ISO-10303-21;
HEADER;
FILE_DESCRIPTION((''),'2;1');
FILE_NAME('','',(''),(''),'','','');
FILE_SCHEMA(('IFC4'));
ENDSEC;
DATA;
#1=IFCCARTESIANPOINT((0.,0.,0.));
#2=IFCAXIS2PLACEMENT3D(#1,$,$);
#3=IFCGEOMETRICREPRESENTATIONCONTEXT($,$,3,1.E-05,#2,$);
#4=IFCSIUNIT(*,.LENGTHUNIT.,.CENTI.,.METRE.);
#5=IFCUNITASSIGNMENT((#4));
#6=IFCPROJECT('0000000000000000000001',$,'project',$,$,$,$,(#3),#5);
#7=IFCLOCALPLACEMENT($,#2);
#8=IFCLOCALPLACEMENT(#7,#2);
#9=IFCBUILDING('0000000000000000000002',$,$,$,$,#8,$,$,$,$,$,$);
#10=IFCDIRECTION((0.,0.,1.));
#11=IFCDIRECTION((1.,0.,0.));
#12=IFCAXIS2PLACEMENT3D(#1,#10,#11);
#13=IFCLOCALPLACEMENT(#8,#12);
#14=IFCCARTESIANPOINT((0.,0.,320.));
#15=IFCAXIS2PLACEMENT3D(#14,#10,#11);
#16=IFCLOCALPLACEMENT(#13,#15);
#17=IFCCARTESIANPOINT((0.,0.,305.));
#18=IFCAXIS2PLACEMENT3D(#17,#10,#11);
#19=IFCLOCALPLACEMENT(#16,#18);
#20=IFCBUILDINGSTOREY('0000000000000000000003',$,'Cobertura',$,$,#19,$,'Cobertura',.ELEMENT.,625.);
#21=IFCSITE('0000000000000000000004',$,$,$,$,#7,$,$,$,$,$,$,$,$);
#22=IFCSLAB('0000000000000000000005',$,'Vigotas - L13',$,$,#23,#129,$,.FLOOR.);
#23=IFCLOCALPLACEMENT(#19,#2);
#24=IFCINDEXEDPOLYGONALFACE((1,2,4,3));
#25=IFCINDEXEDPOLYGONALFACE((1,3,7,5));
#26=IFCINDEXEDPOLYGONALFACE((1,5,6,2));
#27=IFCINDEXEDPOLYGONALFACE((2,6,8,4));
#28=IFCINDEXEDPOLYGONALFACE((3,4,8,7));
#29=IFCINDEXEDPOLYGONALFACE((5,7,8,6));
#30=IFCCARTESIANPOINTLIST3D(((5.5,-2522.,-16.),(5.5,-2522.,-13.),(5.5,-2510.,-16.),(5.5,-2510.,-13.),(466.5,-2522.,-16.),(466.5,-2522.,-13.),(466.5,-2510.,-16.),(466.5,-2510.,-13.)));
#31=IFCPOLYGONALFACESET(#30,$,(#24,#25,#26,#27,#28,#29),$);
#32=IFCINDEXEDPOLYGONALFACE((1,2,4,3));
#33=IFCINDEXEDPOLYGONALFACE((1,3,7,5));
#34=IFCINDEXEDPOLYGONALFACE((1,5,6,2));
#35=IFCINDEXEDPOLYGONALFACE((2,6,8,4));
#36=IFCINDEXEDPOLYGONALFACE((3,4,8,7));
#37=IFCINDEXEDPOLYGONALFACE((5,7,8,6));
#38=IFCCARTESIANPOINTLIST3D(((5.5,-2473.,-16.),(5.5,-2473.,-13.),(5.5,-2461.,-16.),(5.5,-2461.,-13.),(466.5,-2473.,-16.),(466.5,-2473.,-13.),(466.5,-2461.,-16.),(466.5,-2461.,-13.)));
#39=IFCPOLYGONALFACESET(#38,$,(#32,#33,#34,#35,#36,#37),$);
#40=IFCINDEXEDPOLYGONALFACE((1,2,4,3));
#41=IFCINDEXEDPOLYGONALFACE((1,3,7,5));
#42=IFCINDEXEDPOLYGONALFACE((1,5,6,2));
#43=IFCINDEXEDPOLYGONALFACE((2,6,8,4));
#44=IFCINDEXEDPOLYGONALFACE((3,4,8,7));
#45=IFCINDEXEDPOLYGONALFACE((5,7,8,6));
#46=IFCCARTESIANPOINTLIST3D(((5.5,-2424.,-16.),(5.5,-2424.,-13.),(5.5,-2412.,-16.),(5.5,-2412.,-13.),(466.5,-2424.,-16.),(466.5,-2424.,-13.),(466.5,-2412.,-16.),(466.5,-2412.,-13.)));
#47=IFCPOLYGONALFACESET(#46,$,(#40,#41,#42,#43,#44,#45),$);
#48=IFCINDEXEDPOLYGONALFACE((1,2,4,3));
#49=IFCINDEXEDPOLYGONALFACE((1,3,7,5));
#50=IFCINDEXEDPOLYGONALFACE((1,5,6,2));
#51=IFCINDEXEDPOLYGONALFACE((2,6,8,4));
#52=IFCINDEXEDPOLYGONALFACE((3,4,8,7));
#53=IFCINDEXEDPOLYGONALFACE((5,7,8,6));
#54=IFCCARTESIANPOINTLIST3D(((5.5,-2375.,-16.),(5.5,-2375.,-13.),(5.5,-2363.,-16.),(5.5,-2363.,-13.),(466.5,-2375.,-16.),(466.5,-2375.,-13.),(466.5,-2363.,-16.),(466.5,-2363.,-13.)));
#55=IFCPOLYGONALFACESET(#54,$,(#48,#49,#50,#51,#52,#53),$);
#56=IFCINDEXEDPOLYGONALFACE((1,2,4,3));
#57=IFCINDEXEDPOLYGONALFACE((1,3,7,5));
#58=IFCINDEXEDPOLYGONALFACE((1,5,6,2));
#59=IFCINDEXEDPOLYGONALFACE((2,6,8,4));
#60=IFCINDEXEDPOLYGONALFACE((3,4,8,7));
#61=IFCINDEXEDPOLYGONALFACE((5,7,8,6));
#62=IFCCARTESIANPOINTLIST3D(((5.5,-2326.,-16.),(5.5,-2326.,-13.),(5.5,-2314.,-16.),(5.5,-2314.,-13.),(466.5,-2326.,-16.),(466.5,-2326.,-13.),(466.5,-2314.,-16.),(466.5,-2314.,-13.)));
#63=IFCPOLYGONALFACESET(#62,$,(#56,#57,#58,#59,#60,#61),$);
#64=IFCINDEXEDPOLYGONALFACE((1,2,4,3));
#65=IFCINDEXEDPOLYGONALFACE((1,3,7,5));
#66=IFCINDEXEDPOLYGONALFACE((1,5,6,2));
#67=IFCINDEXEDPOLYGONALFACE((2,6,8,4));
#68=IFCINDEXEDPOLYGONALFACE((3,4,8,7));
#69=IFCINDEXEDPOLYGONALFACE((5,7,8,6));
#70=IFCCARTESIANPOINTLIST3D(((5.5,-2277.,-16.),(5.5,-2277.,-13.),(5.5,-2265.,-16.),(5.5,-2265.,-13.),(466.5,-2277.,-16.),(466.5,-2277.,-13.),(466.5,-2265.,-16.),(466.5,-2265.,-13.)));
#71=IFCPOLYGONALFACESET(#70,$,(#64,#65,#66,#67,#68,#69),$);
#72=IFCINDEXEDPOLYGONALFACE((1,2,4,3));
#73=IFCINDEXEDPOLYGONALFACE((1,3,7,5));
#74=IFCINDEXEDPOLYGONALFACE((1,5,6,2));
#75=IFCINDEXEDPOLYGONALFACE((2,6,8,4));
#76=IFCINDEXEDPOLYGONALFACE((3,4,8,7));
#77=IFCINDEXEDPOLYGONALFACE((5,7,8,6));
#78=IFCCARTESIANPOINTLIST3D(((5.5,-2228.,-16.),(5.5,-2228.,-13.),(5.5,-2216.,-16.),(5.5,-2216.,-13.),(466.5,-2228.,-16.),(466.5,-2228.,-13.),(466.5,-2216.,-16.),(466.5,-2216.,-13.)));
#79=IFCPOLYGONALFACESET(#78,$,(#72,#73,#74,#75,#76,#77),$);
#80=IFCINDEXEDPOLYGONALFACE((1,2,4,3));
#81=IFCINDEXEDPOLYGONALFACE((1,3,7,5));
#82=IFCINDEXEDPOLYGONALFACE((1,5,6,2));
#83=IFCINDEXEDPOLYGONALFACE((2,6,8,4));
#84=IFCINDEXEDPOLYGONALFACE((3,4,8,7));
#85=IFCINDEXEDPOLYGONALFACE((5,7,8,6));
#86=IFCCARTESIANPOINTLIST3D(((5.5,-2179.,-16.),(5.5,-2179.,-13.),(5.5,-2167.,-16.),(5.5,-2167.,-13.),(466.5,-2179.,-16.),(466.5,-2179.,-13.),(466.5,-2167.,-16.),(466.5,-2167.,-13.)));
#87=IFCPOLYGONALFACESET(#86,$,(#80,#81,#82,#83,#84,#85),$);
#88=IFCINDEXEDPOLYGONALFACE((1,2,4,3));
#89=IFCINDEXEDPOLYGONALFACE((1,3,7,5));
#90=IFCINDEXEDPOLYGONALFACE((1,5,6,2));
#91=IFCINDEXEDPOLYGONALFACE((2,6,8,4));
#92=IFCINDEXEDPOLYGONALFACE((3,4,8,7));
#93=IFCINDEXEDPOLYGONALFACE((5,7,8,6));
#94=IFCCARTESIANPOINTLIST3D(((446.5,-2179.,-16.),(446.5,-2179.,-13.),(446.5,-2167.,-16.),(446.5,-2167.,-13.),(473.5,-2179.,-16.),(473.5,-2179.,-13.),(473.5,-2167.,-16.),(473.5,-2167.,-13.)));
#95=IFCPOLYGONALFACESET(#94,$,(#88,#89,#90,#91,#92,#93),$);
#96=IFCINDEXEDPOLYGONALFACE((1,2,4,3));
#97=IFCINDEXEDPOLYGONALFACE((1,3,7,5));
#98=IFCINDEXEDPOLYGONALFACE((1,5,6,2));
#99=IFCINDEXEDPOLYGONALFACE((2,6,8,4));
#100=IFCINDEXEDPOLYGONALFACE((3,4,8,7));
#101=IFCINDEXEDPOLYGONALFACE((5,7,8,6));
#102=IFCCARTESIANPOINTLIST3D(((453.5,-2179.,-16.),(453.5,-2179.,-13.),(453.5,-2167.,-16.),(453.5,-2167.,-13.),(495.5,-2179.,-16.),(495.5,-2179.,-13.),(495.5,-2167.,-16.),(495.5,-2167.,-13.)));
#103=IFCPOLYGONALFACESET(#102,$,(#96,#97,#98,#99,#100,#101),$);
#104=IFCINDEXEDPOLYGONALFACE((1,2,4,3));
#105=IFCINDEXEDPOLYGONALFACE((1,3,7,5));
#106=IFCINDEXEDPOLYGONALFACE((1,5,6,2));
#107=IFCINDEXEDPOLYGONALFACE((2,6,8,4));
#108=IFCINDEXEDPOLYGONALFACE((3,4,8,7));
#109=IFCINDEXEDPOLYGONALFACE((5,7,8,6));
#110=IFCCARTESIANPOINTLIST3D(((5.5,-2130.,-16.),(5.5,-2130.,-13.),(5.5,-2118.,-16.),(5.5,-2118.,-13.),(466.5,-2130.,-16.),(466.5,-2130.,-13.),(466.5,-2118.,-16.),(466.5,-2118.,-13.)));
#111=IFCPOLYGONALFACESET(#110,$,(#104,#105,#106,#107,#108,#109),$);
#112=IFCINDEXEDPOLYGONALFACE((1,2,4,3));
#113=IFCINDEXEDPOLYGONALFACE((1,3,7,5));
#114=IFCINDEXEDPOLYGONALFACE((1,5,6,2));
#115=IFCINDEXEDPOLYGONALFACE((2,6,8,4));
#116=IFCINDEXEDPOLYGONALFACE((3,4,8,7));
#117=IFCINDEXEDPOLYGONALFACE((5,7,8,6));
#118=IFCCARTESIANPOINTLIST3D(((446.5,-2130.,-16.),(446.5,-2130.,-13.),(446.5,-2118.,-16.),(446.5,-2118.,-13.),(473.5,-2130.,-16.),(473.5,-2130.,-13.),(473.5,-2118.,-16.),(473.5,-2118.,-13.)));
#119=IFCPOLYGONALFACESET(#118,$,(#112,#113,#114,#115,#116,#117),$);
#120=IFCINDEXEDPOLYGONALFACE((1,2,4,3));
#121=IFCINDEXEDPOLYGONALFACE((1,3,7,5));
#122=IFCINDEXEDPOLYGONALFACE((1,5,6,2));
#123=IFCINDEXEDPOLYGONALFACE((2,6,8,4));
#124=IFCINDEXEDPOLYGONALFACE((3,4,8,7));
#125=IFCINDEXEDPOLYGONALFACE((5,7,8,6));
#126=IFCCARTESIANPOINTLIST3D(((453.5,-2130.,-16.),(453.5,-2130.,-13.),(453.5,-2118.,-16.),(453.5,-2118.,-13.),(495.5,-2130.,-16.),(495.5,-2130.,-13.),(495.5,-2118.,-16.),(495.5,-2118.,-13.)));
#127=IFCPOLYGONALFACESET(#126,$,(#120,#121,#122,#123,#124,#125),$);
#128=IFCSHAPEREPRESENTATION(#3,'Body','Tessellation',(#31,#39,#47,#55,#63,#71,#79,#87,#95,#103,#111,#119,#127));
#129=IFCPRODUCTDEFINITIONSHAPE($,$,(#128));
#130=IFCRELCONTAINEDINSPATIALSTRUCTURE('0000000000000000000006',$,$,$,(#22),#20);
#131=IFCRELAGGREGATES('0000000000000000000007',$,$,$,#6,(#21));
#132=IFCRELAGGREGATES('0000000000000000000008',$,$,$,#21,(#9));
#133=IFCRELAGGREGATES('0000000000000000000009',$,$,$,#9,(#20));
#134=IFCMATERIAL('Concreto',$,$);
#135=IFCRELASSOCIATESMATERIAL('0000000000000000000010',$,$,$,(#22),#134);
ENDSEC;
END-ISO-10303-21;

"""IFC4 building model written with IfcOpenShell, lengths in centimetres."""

from ifc_helpers import new_model, si_unit, frame, origin, origin_with_axes, place, context, project, spatial, polyline, outline, extrude, material, element, save


model = new_model("IFC4")

# Units and contexts
context_of_model = context(None, 3, precision=1e-05, world=origin())
ifc_project = project(units=[si_unit("LENGTHUNIT", "METRE", prefix="CENTI")], contexts=[context_of_model])

# Site, building, storey
site_placement = place(None, origin())
site = spatial("IfcSite", under=ifc_project, at=site_placement)
building_placement = place(site_placement, origin())
building = spatial("IfcBuilding", under=site, at=building_placement)
placement_1 = place(building_placement, origin_with_axes())
placement_2 = place(placement_1, frame((0.0, 0.0, 320.0), z_axis=(0.0, 0.0, 1.0), x_axis=(1.0, 0.0, 0.0)))
storey_placement = place(placement_2, frame((0.0, 0.0, 305.0), z_axis=(0.0, 0.0, 1.0), x_axis=(1.0, 0.0, 0.0)))
storey = spatial("IfcBuildingStorey", under=building, at=storey_placement, Name="Cobertura", LongName="Cobertura", CompositionType="ELEMENT", Elevation=625.0)

# Shared definitions
ifc_material = material(Name="Concreto")

# Slab
slab_1_placement = place(storey_placement, frame((250.5, -2320.0, -13.0), z_axis=(0.0, 0.0, 1.0), x_axis=(1.0, 0.0, 0.0)))
element("IfcSlab", 1, at=slab_1_placement, inside=storey, material=ifc_material, Name="Vigotas - L13", PredefinedType="FLOOR", context=context_of_model, shape_type="SolidModel", body=[
    extrude(outline(polyline([(6.0, 1.5), (-6.0, 1.5), (-6.0, -1.5), (6.0, -1.5), (6.0, 1.5), (6.0, 1.5)])), frame((-245.0, -196.0, -1.5), z_axis=(1.0, 0.0, 0.0), x_axis=(0.0, -1.0, 0.0)), (0.0, 0.0, 1.0), 461.0),
    extrude(outline(polyline([(6.0, 1.5), (-6.0, 1.5), (-6.0, -1.5), (6.0, -1.5), (6.0, 1.5), (6.0, 1.5)])), frame((-245.0, -147.0, -1.5), z_axis=(1.0, 0.0, 0.0), x_axis=(0.0, -1.0, 0.0)), (0.0, 0.0, 1.0), 461.0),
    extrude(outline(polyline([(6.0, 1.5), (-6.0, 1.5), (-6.0, -1.5), (6.0, -1.5), (6.0, 1.5), (6.0, 1.5)])), frame((-245.0, -98.0, -1.5), z_axis=(1.0, 0.0, 0.0), x_axis=(0.0, -1.0, 0.0)), (0.0, 0.0, 1.0), 461.0),
    extrude(outline(polyline([(6.0, 1.5), (-6.0, 1.5), (-6.0, -1.5), (6.0, -1.5), (6.0, 1.5), (6.0, 1.5)])), frame((-245.0, -49.0, -1.5), z_axis=(1.0, 0.0, 0.0), x_axis=(0.0, -1.0, 0.0)), (0.0, 0.0, 1.0), 461.0),
    extrude(outline(polyline([(6.0, 1.5), (-6.0, 1.5), (-6.0, -1.5), (6.0, -1.5), (6.0, 1.5), (6.0, 1.5)])), frame((-245.0, 0.0, -1.5), z_axis=(1.0, 0.0, 0.0), x_axis=(0.0, -1.0, 0.0)), (0.0, 0.0, 1.0), 461.0),
    extrude(outline(polyline([(6.0, 1.5), (-6.0, 1.5), (-6.0, -1.5), (6.0, -1.5), (6.0, 1.5), (6.0, 1.5)])), frame((-245.0, 49.0, -1.5), z_axis=(1.0, 0.0, 0.0), x_axis=(0.0, -1.0, 0.0)), (0.0, 0.0, 1.0), 461.0),
    extrude(outline(polyline([(6.0, 1.5), (-6.0, 1.5), (-6.0, -1.5), (6.0, -1.5), (6.0, 1.5), (6.0, 1.5)])), frame((-245.0, 98.0, -1.5), z_axis=(1.0, 0.0, 0.0), x_axis=(0.0, -1.0, 0.0)), (0.0, 0.0, 1.0), 461.0),
    extrude(outline(polyline([(6.0, 1.5), (-6.0, 1.5), (-6.0, -1.5), (6.0, -1.5), (6.0, 1.5), (6.0, 1.5)])), frame((-245.0, 147.0, -1.5), z_axis=(1.0, 0.0, 0.0), x_axis=(0.0, -1.0, 0.0)), (0.0, 0.0, 1.0), 461.0),
    extrude(outline(polyline([(6.0, 1.5), (-6.0, 1.5), (-6.0, -1.5), (6.0, -1.5), (6.0, 1.5), (6.0, 1.5)])), frame((196.0, 147.0, -1.5), z_axis=(1.0, 0.0, 0.0), x_axis=(0.0, -1.0, 0.0)), (0.0, 0.0, 1.0), 27.0),
    extrude(outline(polyline([(6.0, 1.5), (-6.0, 1.5), (-6.0, -1.5), (6.0, -1.5), (6.0, 1.5), (6.0, 1.5)])), frame((203.0, 147.0, -1.5), z_axis=(1.0, 0.0, 0.0), x_axis=(0.0, -1.0, 0.0)), (0.0, 0.0, 1.0), 42.0),
    extrude(outline(polyline([(6.0, 1.5), (-6.0, 1.5), (-6.0, -1.5), (6.0, -1.5), (6.0, 1.5), (6.0, 1.5)])), frame((-245.0, 196.0, -1.5), z_axis=(1.0, 0.0, 0.0), x_axis=(0.0, -1.0, 0.0)), (0.0, 0.0, 1.0), 461.0),
    extrude(outline(polyline([(6.0, 1.5), (-6.0, 1.5), (-6.0, -1.5), (6.0, -1.5), (6.0, 1.5), (6.0, 1.5)])), frame((196.0, 196.0, -1.5), z_axis=(1.0, 0.0, 0.0), x_axis=(0.0, -1.0, 0.0)), (0.0, 0.0, 1.0), 27.0),
    extrude(outline(polyline([(6.0, 1.5), (-6.0, 1.5), (-6.0, -1.5), (6.0, -1.5), (6.0, 1.5), (6.0, 1.5)])), frame((203.0, 196.0, -1.5), z_axis=(1.0, 0.0, 0.0), x_axis=(0.0, -1.0, 0.0)), (0.0, 0.0, 1.0), 42.0),
])

save(model, "model.ifc")
